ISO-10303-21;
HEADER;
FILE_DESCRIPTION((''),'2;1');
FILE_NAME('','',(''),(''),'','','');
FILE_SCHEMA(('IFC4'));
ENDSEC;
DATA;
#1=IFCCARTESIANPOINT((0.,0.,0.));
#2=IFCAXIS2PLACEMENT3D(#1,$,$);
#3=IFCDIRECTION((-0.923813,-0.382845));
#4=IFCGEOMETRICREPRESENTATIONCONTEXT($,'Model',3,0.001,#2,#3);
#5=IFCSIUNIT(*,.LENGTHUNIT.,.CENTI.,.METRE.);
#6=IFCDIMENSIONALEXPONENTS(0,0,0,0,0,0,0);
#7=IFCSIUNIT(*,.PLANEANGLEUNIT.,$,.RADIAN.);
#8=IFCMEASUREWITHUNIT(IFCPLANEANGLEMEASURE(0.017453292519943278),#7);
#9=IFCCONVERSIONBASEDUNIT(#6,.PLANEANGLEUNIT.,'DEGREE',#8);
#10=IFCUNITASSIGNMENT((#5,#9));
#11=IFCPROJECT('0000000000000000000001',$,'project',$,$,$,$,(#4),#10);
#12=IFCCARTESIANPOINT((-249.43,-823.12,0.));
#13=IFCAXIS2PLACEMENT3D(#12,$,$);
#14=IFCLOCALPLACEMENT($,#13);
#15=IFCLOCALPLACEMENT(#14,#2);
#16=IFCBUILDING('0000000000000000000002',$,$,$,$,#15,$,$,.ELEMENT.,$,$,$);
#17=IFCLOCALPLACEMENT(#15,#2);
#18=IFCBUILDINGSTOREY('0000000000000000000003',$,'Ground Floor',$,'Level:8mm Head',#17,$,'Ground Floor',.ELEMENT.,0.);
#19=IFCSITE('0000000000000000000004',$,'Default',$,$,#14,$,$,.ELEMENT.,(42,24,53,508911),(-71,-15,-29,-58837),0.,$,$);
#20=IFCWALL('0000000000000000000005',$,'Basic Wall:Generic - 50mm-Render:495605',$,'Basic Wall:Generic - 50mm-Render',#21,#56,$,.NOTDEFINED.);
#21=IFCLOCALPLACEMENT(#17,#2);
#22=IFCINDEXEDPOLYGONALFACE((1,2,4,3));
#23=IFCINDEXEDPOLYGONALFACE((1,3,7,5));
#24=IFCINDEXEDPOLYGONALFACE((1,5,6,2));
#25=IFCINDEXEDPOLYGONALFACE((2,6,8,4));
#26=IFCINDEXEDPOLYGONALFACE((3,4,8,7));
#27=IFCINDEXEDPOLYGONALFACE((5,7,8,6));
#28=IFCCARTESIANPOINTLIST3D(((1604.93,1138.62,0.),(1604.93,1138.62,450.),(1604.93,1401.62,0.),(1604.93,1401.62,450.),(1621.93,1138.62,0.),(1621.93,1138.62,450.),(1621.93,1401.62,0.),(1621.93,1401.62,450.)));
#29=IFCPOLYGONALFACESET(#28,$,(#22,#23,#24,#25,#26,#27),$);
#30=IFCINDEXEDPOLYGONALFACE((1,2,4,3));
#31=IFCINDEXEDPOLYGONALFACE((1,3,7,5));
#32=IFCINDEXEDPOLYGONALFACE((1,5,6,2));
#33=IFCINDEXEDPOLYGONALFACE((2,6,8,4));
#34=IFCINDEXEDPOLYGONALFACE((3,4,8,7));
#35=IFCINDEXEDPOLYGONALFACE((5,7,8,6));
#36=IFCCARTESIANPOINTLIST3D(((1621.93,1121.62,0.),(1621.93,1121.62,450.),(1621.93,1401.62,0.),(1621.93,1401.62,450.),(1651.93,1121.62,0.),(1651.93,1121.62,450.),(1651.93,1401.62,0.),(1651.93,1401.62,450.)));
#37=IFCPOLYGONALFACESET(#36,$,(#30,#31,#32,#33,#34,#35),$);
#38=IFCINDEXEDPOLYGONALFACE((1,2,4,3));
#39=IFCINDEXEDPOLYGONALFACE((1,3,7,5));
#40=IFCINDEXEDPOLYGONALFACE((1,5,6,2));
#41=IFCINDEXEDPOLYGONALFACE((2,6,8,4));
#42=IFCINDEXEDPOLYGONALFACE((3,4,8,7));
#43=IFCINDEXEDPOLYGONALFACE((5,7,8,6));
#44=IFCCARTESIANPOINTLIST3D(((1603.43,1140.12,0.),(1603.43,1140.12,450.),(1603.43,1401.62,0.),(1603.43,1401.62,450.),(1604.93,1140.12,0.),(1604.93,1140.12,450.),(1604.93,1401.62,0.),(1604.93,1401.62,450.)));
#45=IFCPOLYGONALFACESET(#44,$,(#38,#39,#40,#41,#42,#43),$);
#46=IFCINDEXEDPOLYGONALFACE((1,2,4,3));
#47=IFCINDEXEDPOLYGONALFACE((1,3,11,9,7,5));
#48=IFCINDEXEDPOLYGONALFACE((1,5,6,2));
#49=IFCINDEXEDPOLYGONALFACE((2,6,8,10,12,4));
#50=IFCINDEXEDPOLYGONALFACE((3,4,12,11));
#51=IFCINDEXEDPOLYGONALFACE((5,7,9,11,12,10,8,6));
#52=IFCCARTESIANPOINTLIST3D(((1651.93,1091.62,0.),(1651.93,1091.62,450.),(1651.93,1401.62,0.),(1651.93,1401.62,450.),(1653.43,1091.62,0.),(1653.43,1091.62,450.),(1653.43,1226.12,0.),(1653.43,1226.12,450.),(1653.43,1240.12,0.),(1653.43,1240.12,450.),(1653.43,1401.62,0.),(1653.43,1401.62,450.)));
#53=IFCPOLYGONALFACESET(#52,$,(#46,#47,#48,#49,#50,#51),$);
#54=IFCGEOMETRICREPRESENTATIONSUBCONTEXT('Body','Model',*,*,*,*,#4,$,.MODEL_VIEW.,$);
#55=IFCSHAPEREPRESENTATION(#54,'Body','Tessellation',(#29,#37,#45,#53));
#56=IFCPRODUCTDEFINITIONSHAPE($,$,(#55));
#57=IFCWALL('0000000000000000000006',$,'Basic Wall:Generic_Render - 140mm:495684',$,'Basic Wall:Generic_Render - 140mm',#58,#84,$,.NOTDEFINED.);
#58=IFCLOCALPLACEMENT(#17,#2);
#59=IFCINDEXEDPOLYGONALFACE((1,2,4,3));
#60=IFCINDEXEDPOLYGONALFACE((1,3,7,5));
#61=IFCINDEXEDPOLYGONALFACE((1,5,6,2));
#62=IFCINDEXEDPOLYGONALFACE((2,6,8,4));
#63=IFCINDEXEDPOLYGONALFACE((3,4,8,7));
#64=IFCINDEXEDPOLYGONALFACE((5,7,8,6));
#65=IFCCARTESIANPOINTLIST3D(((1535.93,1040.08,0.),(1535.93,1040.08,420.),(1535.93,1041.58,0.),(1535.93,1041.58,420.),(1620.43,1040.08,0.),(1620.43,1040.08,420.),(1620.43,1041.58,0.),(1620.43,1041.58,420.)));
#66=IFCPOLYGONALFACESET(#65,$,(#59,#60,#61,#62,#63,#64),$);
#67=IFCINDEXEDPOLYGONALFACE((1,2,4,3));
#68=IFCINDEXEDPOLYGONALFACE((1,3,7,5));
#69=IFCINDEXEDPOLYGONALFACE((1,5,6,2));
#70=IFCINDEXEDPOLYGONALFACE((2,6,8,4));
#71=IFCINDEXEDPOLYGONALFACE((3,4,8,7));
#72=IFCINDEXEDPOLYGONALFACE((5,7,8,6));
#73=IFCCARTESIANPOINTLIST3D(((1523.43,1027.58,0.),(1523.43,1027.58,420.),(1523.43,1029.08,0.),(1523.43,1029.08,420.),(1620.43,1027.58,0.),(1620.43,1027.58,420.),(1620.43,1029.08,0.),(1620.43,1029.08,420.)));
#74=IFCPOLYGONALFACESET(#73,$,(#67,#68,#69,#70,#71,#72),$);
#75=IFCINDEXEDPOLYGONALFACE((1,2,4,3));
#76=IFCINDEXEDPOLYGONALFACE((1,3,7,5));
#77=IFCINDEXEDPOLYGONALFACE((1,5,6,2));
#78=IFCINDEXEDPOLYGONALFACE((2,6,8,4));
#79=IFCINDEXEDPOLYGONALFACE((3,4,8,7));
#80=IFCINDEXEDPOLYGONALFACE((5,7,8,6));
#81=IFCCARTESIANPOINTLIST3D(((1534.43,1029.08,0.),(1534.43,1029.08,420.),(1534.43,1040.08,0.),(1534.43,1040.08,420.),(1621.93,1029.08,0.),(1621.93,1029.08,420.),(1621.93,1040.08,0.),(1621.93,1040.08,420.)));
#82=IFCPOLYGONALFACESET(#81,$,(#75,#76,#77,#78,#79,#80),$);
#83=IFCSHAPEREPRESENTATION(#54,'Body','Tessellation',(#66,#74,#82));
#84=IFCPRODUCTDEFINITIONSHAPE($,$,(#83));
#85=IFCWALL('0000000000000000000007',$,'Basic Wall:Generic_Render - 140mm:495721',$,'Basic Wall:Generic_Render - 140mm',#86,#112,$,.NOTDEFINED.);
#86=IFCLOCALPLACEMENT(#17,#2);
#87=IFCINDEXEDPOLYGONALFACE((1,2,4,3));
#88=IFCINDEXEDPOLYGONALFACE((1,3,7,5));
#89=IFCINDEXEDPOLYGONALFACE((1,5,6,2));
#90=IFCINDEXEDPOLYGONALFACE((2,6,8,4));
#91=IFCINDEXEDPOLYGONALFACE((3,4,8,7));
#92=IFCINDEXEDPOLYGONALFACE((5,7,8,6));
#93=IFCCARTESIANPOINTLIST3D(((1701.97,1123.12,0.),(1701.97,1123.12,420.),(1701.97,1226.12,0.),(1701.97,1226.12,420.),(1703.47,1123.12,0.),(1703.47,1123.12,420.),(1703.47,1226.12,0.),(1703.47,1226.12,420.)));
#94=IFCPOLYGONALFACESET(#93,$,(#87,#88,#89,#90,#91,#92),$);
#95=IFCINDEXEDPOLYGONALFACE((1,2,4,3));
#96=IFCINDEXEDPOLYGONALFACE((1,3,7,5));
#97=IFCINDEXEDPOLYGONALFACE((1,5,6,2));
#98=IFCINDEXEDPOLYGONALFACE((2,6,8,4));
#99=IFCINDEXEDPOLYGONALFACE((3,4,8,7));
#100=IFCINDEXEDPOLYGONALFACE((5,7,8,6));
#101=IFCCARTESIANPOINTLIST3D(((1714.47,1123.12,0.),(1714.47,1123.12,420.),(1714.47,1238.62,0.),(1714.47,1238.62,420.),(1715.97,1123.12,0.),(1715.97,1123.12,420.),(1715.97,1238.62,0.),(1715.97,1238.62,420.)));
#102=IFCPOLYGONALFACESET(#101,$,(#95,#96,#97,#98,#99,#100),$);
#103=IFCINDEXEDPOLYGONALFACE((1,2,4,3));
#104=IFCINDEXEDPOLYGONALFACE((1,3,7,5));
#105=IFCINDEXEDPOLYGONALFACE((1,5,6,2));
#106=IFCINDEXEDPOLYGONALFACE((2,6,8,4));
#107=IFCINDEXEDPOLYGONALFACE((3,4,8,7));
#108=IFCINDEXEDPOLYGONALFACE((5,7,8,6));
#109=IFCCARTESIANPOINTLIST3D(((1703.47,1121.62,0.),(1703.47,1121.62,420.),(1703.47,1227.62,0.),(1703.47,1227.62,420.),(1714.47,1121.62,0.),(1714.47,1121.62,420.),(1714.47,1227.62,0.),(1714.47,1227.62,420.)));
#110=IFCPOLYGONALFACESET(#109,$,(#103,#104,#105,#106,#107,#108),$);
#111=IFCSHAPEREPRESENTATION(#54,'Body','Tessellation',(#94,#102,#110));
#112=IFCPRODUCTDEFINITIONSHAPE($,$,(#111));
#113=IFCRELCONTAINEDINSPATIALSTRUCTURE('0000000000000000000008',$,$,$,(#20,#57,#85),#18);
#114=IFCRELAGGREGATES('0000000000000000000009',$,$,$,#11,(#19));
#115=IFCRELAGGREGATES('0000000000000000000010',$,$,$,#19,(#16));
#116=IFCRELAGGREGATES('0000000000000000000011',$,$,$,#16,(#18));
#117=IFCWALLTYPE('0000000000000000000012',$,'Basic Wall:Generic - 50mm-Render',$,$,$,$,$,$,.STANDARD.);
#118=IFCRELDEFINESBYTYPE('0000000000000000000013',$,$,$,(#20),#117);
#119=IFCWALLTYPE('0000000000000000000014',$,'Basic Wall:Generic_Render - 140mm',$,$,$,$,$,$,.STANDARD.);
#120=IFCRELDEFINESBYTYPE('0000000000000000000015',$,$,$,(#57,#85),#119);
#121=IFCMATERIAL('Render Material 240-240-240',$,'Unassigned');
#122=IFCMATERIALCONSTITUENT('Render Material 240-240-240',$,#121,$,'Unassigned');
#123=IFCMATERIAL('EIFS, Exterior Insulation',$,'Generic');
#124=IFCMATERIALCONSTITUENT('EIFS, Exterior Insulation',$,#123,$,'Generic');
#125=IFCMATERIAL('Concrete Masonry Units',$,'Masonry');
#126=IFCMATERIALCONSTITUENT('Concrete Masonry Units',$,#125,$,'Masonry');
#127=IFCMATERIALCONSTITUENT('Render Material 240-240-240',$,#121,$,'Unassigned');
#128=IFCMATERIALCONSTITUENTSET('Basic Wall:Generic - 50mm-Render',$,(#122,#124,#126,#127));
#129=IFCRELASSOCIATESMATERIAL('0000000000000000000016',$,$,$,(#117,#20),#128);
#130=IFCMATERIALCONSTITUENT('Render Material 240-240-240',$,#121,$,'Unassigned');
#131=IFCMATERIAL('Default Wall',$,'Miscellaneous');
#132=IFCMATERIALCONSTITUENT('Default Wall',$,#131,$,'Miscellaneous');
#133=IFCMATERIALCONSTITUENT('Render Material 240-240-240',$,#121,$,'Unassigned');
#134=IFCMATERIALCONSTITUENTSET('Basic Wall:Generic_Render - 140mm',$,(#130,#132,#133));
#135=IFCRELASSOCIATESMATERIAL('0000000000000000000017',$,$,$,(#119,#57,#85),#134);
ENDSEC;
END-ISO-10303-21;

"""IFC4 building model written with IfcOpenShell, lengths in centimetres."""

from ifc_helpers import new_model, entity, si_unit, converted_unit, direction, frame, origin, place, context, subcontext, project, spatial, indexed_curve, outline, extrude, material, constituent, constituent_set, type_object, element, save


model = new_model("IFC4")

# Units and contexts
model_context = context("Model", 3, precision=0.001, world=origin(), true_north=direction((-0.923813, -0.382845)))
body_context = subcontext(model_context, "Body", "Model", "MODEL_VIEW")
ifc_project = project(units=[si_unit("LENGTHUNIT", "METRE", prefix="CENTI"), converted_unit("PLANEANGLEUNIT", "DEGREE", entity("IfcPlaneAngleMeasure", 0.017453292519943278), si_unit("PLANEANGLEUNIT", "RADIAN"), dimensions=[0, 0, 0, 0, 0, 0, 0])], contexts=[model_context])

# Site, building, storey
site_placement = place(None, frame((-249.43, -823.12, 0.0)))
site = spatial("IfcSite", under=ifc_project, at=site_placement, Name="Default", CompositionType="ELEMENT", RefLatitude=(42, 24, 53, 508911), RefLongitude=(-71, -15, -29, -58837), RefElevation=0.0)
building_placement = place(site_placement, origin())
building = spatial("IfcBuilding", under=site, at=building_placement, CompositionType="ELEMENT")
storey_placement = place(building_placement, origin())
storey = spatial("IfcBuildingStorey", under=building, at=storey_placement, Name="Ground Floor", ObjectType="Level:8mm Head", LongName="Ground Floor", CompositionType="ELEMENT", Elevation=0.0)

# Walls
ifc_material_1 = material(Name="Render Material 240-240-240", Category="Unassigned")
ifc_constituent_1 = constituent(ifc_material_1, Name="Render Material 240-240-240", Category="Unassigned")
ifc_material_2 = material(Name="EIFS, Exterior Insulation", Category="Generic")
ifc_constituent_2 = constituent(ifc_material_2, Name="EIFS, Exterior Insulation", Category="Generic")
ifc_material_3 = material(Name="Concrete Masonry Units", Category="Masonry")
ifc_constituent_3 = constituent(ifc_material_3, Name="Concrete Masonry Units", Category="Masonry")
ifc_constituent_4 = constituent(ifc_material_1, Name="Render Material 240-240-240", Category="Unassigned")
ifc_constituent_set_1 = constituent_set(constituents=[ifc_constituent_1, ifc_constituent_2, ifc_constituent_3, ifc_constituent_4], Name="Basic Wall:Generic - 50mm-Render")
wall_type_1 = type_object("IfcWallType", Name="Basic Wall:Generic - 50mm-Render", PredefinedType="STANDARD", material=ifc_constituent_set_1)
wall_1_placement = place(storey_placement, frame((1628.43, 1401.62, 0.0), z_axis=(0.0, 0.0, 1.0), x_axis=(0.0, -1.0, 0.0)))
element("IfcWall", 1, at=wall_1_placement, inside=storey, type_object=wall_type_1, material=ifc_constituent_set_1, Name="Basic Wall:Generic - 50mm-Render:495605", ObjectType="Basic Wall:Generic - 50mm-Render", PredefinedType="NOTDEFINED", context=body_context, shape_type="SweptSolid", body=[
    extrude(outline(indexed_curve([(-131.5, -8.5), (131.5, -8.5), (131.5, 8.5), (-131.5, 8.5), (-131.5, -8.5)], self_intersect=False)), frame((131.5, -15.0, 0.0)), (0.0, 0.0, 1.0), 450.0),
    extrude(outline(indexed_curve([(-140.0, -15.0), (140.0, -15.0), (140.0, 15.0), (-140.0, 15.0), (-140.0, -15.0)], self_intersect=False)), frame((140.0, 8.5, 0.0)), (0.0, 0.0, 1.0), 450.0),
    extrude(outline(indexed_curve([(-0.75, -130.75), (0.75, -130.75), (0.75, 130.75), (-0.75, 130.75), (-0.75, -130.75)], self_intersect=False)), frame((130.75, -24.25, 0.0), z_axis=(0.0, 0.0, 1.0), x_axis=(0.0, 1.0, 0.0)), (0.0, 0.0, 1.0), 450.0),
    extrude(outline(indexed_curve([(-16.0, -0.5), (-2.0, -0.5), (159.5, -0.5), (159.5, 1.0), (-150.5, 1.0), (-150.5, -0.5), (-16.0, -0.5)], self_intersect=False)), frame((159.5, 24.5, 0.0), z_axis=(0.0, 0.0, 1.0), x_axis=(-1.0, 0.0, 0.0)), (0.0, 0.0, 1.0), 450.0),
])
ifc_constituent_5 = constituent(ifc_material_1, Name="Render Material 240-240-240", Category="Unassigned")
ifc_material_4 = material(Name="Default Wall", Category="Miscellaneous")
ifc_constituent_6 = constituent(ifc_material_4, Name="Default Wall", Category="Miscellaneous")
ifc_constituent_7 = constituent(ifc_material_1, Name="Render Material 240-240-240", Category="Unassigned")
ifc_constituent_set_2 = constituent_set(constituents=[ifc_constituent_5, ifc_constituent_6, ifc_constituent_7], Name="Basic Wall:Generic_Render - 140mm")
wall_type_2 = type_object("IfcWallType", Name="Basic Wall:Generic_Render - 140mm", PredefinedType="STANDARD", material=ifc_constituent_set_2)
wall_2_placement = place(storey_placement, frame((1535.93, 1034.58, 0.0)))
element("IfcWall", 2, at=wall_2_placement, inside=storey, type_object=wall_type_2, material=ifc_constituent_set_2, Name="Basic Wall:Generic_Render - 140mm:495684", ObjectType="Basic Wall:Generic_Render - 140mm", PredefinedType="NOTDEFINED", context=body_context, shape_type="SweptSolid", body=[
    extrude(outline(indexed_curve([(-0.75, -42.25), (0.75, -42.25), (0.75, 42.25), (-0.75, 42.25), (-0.75, -42.25)], self_intersect=False)), frame((42.25, 6.25, 0.0), z_axis=(0.0, 0.0, 1.0), x_axis=(0.0, -1.0, 0.0)), (0.0, 0.0, 1.0), 420.0),
    extrude(outline(indexed_curve([(-0.75, -48.5), (0.75, -48.5), (0.75, 48.5), (-0.75, 48.5), (-0.75, -48.5)], self_intersect=False)), frame((36.0, -6.25, 0.0), z_axis=(0.0, 0.0, 1.0), x_axis=(0.0, 1.0, 0.0)), (0.0, 0.0, 1.0), 420.0),
    extrude(outline(indexed_curve([(-43.75, -5.5), (43.75, -5.5), (43.75, 5.5), (-43.75, 5.5), (-43.75, -5.5)], self_intersect=False)), frame((42.25, 0.0, 0.0)), (0.0, 0.0, 1.0), 420.0),
])
wall_3_placement = place(storey_placement, frame((1708.97, 1226.12, 0.0), z_axis=(0.0, 0.0, 1.0), x_axis=(0.0, -1.0, 0.0)))
element("IfcWall", 3, at=wall_3_placement, inside=storey, type_object=wall_type_2, material=ifc_constituent_set_2, Name="Basic Wall:Generic_Render - 140mm:495721", ObjectType="Basic Wall:Generic_Render - 140mm", PredefinedType="NOTDEFINED", context=body_context, shape_type="SweptSolid", body=[
    extrude(outline(indexed_curve([(-0.75, -51.5), (0.75, -51.5), (0.75, 51.5), (-0.75, 51.5), (-0.75, -51.5)], self_intersect=False)), frame((51.5, -6.25, 0.0), z_axis=(0.0, 0.0, 1.0), x_axis=(0.0, 1.0, 0.0)), (0.0, 0.0, 1.0), 420.0),
    extrude(outline(indexed_curve([(-0.75, -57.75), (0.75, -57.75), (0.75, 57.75), (-0.75, 57.75), (-0.75, -57.75)], self_intersect=False)), frame((45.25, 6.25, 0.0), z_axis=(0.0, 0.0, 1.0), x_axis=(0.0, -1.0, 0.0)), (0.0, 0.0, 1.0), 420.0),
    extrude(outline(indexed_curve([(-53.0, -5.5), (53.0, -5.5), (53.0, 5.5), (-53.0, 5.5), (-53.0, -5.5)], self_intersect=False)), frame((51.5, 0.0, 0.0)), (0.0, 0.0, 1.0), 420.0),
])

save(model, "model.ifc")
